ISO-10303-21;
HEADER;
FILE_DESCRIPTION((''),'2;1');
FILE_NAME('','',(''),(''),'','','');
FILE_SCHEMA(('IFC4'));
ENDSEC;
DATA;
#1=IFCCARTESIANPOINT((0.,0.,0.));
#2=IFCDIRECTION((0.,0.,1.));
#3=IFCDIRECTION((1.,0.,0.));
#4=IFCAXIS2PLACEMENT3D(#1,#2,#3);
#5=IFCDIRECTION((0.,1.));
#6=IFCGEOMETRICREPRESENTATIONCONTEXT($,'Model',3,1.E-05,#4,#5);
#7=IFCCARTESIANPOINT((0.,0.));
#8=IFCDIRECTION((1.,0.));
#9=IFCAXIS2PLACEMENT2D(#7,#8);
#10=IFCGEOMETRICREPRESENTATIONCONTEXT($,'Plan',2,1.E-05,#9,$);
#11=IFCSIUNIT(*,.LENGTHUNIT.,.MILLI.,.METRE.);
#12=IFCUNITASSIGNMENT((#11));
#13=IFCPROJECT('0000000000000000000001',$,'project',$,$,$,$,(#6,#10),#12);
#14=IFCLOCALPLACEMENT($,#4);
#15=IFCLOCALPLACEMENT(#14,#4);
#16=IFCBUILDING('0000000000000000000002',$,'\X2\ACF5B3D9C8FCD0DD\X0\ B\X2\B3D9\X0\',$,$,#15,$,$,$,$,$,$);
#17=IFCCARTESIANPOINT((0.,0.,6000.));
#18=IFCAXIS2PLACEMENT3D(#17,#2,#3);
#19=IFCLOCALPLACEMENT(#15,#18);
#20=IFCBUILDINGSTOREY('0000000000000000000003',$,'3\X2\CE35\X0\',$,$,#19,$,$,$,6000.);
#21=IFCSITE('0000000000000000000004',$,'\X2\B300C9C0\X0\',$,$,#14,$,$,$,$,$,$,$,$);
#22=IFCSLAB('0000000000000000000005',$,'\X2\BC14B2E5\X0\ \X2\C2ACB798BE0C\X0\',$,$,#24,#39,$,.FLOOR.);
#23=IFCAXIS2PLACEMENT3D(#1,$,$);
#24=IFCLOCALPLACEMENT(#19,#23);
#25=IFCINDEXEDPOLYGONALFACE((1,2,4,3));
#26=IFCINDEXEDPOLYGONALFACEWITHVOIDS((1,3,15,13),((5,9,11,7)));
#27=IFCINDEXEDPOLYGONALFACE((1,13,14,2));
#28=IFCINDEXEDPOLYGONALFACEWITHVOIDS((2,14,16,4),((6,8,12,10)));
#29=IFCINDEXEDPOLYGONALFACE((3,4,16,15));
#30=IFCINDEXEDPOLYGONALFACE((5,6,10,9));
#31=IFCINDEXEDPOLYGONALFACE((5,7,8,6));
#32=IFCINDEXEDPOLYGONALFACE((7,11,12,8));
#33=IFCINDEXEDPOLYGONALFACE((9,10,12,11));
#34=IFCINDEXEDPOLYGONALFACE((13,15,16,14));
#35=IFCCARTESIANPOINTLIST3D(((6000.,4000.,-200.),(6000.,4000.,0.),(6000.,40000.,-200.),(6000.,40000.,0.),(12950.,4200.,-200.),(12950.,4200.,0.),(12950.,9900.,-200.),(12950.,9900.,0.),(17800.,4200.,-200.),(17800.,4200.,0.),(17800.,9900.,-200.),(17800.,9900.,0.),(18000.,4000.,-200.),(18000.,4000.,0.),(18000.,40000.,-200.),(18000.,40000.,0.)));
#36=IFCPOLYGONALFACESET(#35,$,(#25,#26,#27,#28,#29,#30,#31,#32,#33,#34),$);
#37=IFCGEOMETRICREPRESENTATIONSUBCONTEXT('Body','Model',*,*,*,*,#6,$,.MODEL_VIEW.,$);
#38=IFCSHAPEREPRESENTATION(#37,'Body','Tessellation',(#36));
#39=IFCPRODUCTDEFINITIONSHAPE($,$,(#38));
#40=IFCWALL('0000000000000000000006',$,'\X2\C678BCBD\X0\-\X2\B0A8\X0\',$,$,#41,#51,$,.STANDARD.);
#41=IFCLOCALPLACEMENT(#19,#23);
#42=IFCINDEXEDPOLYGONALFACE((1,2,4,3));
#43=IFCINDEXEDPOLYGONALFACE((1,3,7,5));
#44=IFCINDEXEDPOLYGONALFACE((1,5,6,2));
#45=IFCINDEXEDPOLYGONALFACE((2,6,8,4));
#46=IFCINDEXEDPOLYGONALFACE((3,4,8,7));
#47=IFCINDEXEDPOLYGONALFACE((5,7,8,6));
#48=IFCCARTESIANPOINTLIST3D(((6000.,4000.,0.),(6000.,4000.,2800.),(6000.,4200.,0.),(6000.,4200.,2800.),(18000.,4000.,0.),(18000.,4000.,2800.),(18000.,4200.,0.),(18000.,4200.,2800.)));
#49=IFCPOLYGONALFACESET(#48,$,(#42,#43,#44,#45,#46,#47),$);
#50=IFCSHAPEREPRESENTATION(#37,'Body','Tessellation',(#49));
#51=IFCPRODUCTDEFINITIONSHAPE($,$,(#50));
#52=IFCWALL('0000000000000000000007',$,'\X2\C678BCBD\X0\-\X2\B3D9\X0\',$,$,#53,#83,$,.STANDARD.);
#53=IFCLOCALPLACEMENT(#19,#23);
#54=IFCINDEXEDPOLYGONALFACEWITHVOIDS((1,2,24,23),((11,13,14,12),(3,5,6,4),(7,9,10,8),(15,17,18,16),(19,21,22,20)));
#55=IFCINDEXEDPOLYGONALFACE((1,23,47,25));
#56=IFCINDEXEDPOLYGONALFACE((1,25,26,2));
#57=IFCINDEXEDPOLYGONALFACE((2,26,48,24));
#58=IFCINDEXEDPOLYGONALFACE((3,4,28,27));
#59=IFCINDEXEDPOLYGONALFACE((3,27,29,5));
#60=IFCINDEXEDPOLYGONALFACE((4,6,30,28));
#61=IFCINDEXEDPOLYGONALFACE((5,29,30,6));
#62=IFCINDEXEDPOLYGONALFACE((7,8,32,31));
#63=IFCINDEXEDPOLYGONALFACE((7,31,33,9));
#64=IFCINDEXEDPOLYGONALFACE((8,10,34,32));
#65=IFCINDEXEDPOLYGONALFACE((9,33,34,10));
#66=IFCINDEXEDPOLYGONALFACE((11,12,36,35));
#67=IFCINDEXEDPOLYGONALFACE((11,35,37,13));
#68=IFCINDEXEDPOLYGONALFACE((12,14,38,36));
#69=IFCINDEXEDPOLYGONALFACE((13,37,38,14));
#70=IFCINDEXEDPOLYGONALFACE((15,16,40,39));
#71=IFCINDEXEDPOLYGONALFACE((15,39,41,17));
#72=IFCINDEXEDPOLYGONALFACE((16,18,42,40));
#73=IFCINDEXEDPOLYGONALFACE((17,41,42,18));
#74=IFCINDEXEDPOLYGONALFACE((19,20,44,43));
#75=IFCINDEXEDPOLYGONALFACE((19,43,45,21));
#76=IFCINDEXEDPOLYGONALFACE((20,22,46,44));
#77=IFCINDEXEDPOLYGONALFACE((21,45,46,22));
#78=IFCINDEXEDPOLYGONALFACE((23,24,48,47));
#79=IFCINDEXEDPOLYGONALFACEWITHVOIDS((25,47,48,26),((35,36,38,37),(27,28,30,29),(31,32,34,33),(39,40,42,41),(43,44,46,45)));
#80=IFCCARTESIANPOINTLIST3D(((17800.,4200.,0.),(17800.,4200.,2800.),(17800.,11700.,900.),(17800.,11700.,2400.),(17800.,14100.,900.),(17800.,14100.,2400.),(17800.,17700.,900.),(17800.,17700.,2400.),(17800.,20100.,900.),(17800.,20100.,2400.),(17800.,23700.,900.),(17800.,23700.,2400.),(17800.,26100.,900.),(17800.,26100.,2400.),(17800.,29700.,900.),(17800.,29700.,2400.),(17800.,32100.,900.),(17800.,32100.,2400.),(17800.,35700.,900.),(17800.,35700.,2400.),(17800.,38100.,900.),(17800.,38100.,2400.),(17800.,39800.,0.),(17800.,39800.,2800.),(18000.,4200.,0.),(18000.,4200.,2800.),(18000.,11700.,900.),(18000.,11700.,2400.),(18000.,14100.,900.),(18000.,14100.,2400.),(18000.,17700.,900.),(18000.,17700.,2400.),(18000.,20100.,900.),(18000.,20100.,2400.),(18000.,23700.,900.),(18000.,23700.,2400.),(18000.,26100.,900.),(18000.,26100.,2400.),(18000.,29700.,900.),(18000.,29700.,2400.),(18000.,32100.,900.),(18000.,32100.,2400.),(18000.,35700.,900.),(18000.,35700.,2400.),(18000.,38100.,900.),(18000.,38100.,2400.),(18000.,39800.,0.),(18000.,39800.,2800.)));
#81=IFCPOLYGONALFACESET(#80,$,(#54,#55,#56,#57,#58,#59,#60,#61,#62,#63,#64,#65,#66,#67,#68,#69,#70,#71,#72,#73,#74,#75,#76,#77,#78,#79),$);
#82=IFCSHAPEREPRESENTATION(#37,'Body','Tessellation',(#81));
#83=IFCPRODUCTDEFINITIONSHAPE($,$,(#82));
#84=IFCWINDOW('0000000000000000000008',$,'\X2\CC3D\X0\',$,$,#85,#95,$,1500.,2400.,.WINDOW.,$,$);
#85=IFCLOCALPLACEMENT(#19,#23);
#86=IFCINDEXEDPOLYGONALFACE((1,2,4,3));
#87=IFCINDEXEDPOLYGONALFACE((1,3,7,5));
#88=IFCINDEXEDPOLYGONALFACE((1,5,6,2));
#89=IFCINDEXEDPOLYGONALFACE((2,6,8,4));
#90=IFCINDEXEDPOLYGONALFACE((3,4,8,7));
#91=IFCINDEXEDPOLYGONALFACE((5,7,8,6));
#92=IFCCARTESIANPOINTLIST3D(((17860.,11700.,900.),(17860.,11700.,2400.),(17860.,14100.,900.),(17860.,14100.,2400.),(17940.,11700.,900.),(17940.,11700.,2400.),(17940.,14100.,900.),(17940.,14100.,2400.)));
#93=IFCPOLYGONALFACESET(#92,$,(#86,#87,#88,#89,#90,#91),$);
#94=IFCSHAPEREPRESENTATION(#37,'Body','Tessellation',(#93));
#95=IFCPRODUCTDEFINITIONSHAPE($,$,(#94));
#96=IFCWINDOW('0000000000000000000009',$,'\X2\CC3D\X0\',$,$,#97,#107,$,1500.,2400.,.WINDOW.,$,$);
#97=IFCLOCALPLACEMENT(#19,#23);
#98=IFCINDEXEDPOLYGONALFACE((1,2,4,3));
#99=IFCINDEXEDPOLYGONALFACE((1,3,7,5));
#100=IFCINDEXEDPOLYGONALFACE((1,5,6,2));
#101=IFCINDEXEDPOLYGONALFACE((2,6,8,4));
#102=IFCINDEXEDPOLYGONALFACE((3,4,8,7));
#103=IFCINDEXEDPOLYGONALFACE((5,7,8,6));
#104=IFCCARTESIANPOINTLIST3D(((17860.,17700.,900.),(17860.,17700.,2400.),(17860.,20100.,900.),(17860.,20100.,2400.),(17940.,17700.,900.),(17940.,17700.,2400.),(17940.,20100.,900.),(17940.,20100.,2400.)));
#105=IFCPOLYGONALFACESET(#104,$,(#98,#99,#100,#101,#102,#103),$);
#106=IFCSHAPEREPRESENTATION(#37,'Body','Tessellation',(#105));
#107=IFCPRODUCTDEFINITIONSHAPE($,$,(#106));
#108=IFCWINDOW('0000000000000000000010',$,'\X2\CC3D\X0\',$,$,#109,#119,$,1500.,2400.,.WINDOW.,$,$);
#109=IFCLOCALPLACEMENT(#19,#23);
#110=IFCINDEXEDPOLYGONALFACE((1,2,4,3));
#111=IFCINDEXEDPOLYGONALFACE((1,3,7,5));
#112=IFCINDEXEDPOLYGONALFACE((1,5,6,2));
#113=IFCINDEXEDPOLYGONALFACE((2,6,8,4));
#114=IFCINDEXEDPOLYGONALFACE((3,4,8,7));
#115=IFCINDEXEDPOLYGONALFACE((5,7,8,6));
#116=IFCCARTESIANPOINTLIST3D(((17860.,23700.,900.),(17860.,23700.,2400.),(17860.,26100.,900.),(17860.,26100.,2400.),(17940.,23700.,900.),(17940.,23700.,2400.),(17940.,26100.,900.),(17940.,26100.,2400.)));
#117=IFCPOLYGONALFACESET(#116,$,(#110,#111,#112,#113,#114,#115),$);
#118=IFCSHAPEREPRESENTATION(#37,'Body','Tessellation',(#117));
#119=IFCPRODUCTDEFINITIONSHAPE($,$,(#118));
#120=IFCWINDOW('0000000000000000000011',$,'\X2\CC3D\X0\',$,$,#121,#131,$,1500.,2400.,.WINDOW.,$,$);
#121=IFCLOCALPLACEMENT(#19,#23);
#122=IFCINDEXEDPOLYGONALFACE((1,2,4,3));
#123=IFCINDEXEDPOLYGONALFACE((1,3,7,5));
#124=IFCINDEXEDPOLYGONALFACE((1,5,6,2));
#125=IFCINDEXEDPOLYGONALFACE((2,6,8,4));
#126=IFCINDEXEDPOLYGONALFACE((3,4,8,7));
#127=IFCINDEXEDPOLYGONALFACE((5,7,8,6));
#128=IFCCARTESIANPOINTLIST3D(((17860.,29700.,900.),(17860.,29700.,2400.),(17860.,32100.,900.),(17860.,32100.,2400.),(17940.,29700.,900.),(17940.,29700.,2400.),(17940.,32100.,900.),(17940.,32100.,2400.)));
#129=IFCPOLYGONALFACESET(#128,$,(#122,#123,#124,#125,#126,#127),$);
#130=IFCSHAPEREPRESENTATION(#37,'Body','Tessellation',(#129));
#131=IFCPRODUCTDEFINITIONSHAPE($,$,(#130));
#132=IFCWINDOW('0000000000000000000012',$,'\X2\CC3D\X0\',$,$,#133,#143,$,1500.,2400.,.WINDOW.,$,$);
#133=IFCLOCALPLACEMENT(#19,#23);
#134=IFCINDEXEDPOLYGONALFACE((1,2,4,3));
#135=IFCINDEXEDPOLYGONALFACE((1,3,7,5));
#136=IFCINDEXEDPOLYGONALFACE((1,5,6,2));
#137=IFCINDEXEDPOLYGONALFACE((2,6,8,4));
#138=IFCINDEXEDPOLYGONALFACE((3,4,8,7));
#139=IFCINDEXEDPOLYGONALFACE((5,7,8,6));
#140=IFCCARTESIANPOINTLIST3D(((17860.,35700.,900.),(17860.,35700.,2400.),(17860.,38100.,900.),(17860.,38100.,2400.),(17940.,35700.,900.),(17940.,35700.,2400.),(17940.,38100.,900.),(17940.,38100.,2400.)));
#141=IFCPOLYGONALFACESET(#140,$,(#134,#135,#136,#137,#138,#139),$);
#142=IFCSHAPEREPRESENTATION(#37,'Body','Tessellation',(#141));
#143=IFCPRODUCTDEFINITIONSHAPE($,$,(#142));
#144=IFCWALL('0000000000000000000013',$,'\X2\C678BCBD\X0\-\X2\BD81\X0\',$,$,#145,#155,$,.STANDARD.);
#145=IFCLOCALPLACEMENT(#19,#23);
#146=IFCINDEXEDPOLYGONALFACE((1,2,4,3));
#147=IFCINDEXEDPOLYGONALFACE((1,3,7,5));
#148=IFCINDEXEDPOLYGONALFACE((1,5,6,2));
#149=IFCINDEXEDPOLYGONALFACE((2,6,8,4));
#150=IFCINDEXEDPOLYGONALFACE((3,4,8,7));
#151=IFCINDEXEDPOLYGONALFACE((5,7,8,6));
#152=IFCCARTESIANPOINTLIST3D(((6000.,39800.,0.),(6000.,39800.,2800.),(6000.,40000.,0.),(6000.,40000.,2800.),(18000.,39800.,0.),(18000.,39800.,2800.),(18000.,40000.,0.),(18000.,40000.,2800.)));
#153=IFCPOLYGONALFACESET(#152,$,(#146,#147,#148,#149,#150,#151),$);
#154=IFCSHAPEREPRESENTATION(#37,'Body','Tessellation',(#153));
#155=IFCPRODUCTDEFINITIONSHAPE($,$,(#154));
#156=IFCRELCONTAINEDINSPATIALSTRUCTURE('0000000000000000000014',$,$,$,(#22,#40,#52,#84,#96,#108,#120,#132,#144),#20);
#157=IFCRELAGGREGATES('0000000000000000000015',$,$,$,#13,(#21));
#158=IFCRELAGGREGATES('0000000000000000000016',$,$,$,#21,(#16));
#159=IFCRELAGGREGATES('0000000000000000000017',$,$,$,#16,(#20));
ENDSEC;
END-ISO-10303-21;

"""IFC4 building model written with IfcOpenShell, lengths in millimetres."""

from ifc_helpers import new_model, si_unit, direction, frame, origin_with_axes, origin_2d_with_axis, place, context, subcontext, project, spatial, polyline, outline, extrude, element, fill, save


model = new_model("IFC4")

# Units and contexts
model_context = context("Model", 3, precision=1e-05, world=origin_with_axes(), true_north=direction((0.0, 1.0)))
plan_context = context("Plan", 2, precision=1e-05, world=origin_2d_with_axis())
body_context = subcontext(model_context, "Body", "Model", "MODEL_VIEW")
ifc_project = project(units=[si_unit("LENGTHUNIT", "METRE", prefix="MILLI")], contexts=[model_context, plan_context])

# Site, building, storey
site_placement = place(None, origin_with_axes())
site = spatial("IfcSite", under=ifc_project, at=site_placement, Name="대지")
building_placement = place(site_placement, origin_with_axes())
building = spatial("IfcBuilding", under=site, at=building_placement, Name="공동주택 B동")
storey_placement = place(building_placement, frame((0.0, 0.0, 6000.0), z_axis=(0.0, 0.0, 1.0), x_axis=(1.0, 0.0, 0.0)))
storey = spatial("IfcBuildingStorey", under=building, at=storey_placement, Name="3층", Elevation=6000.0)

# Slab
slab_placement = place(storey_placement, origin_with_axes())
element("IfcSlab", 1, at=slab_placement, inside=storey, Name="바닥 슬래브", PredefinedType="FLOOR", context=body_context, shape_type="SweptSolid", body=[
    extrude(outline(polyline([(6000.0, 4000.0), (18000.0, 4000.0), (18000.0, 40000.0), (6000.0, 40000.0), (6000.0, 4000.0)]), holes=[polyline([(12950.0, 4200.0), (17800.0, 4200.0), (17800.0, 9900.0), (12950.0, 9900.0), (12950.0, 4200.0)])]), frame((0.0, 0.0, -200.0), z_axis=(0.0, 0.0, 1.0), x_axis=(1.0, 0.0, 0.0)), (0.0, 0.0, 1.0), 200.0),
])

# Wall
wall_1_placement = place(storey_placement, origin_with_axes())
element("IfcWall", 2, at=wall_1_placement, inside=storey, Name="외벽-남", PredefinedType="STANDARD", context=body_context, shape_type="SweptSolid", body=[
    extrude(outline(polyline([(6000.0, 4200.0), (18000.0, 4200.0), (18000.0, 4000.0), (6000.0, 4000.0), (6000.0, 4200.0)])), origin_with_axes(), (0.0, 0.0, 1.0), 2800.0),
])

# Wall, openings, windows
wall_2_placement = place(storey_placement, origin_with_axes())
wall_2 = element("IfcWall", 3, at=wall_2_placement, inside=storey, Name="외벽-동", PredefinedType="STANDARD", context=body_context, shape_type="SweptSolid", body=[
    extrude(outline(polyline([(17800.0, 4200.0), (17800.0, 39800.0), (18000.0, 39800.0), (18000.0, 4200.0), (17800.0, 4200.0)])), origin_with_axes(), (0.0, 0.0, 1.0), 2800.0),
])
opening_1_placement = place(storey_placement, origin_with_axes())
opening_1 = element("IfcOpeningElement", 4, at=opening_1_placement, cuts=wall_2, PredefinedType="OPENING", context=body_context, shape_type="SweptSolid", body=[
    extrude(outline(polyline([(18050.0, 11700.0), (18050.0, 14100.0), (17750.0, 14100.0), (17750.0, 11700.0), (18050.0, 11700.0)])), frame((0.0, 0.0, 900.0), z_axis=(0.0, 0.0, 1.0), x_axis=(1.0, 0.0, 0.0)), (0.0, 0.0, 1.0), 1500.0),
])
opening_2_placement = place(storey_placement, origin_with_axes())
opening_2 = element("IfcOpeningElement", 5, at=opening_2_placement, cuts=wall_2, PredefinedType="OPENING", context=body_context, shape_type="SweptSolid", body=[
    extrude(outline(polyline([(18050.0, 17700.0), (18050.0, 20100.0), (17750.0, 20100.0), (17750.0, 17700.0), (18050.0, 17700.0)])), frame((0.0, 0.0, 900.0), z_axis=(0.0, 0.0, 1.0), x_axis=(1.0, 0.0, 0.0)), (0.0, 0.0, 1.0), 1500.0),
])
opening_3_placement = place(storey_placement, origin_with_axes())
opening_3 = element("IfcOpeningElement", 6, at=opening_3_placement, cuts=wall_2, PredefinedType="OPENING", context=body_context, shape_type="SweptSolid", body=[
    extrude(outline(polyline([(18050.0, 23700.0), (18050.0, 26100.0), (17750.0, 26100.0), (17750.0, 23700.0), (18050.0, 23700.0)])), frame((0.0, 0.0, 900.0), z_axis=(0.0, 0.0, 1.0), x_axis=(1.0, 0.0, 0.0)), (0.0, 0.0, 1.0), 1500.0),
])
opening_4_placement = place(storey_placement, origin_with_axes())
opening_4 = element("IfcOpeningElement", 7, at=opening_4_placement, cuts=wall_2, PredefinedType="OPENING", context=body_context, shape_type="SweptSolid", body=[
    extrude(outline(polyline([(18050.0, 29700.0), (18050.0, 32100.0), (17750.0, 32100.0), (17750.0, 29700.0), (18050.0, 29700.0)])), frame((0.0, 0.0, 900.0), z_axis=(0.0, 0.0, 1.0), x_axis=(1.0, 0.0, 0.0)), (0.0, 0.0, 1.0), 1500.0),
])
opening_5_placement = place(storey_placement, origin_with_axes())
opening_5 = element("IfcOpeningElement", 8, at=opening_5_placement, cuts=wall_2, PredefinedType="OPENING", context=body_context, shape_type="SweptSolid", body=[
    extrude(outline(polyline([(18050.0, 35700.0), (18050.0, 38100.0), (17750.0, 38100.0), (17750.0, 35700.0), (18050.0, 35700.0)])), frame((0.0, 0.0, 900.0), z_axis=(0.0, 0.0, 1.0), x_axis=(1.0, 0.0, 0.0)), (0.0, 0.0, 1.0), 1500.0),
])
window_1_placement = place(storey_placement, origin_with_axes())
window_1 = element("IfcWindow", 9, at=window_1_placement, inside=storey, Name="창", OverallHeight=1500.0, OverallWidth=2400.0, PredefinedType="WINDOW", context=body_context, shape_type="SweptSolid", body=[
    extrude(outline(polyline([(17940.0, 11700.0), (17940.0, 14100.0), (17860.0, 14100.0), (17860.0, 11700.0), (17940.0, 11700.0)])), frame((0.0, 0.0, 900.0), z_axis=(0.0, 0.0, 1.0), x_axis=(1.0, 0.0, 0.0)), (0.0, 0.0, 1.0), 1500.0),
])
fill(opening_1, window_1)
window_2_placement = place(storey_placement, origin_with_axes())
window_2 = element("IfcWindow", 10, at=window_2_placement, inside=storey, Name="창", OverallHeight=1500.0, OverallWidth=2400.0, PredefinedType="WINDOW", context=body_context, shape_type="SweptSolid", body=[
    extrude(outline(polyline([(17940.0, 17700.0), (17940.0, 20100.0), (17860.0, 20100.0), (17860.0, 17700.0), (17940.0, 17700.0)])), frame((0.0, 0.0, 900.0), z_axis=(0.0, 0.0, 1.0), x_axis=(1.0, 0.0, 0.0)), (0.0, 0.0, 1.0), 1500.0),
])
fill(opening_2, window_2)
window_3_placement = place(storey_placement, origin_with_axes())
window_3 = element("IfcWindow", 11, at=window_3_placement, inside=storey, Name="창", OverallHeight=1500.0, OverallWidth=2400.0, PredefinedType="WINDOW", context=body_context, shape_type="SweptSolid", body=[
    extrude(outline(polyline([(17940.0, 23700.0), (17940.0, 26100.0), (17860.0, 26100.0), (17860.0, 23700.0), (17940.0, 23700.0)])), frame((0.0, 0.0, 900.0), z_axis=(0.0, 0.0, 1.0), x_axis=(1.0, 0.0, 0.0)), (0.0, 0.0, 1.0), 1500.0),
])
fill(opening_3, window_3)
window_4_placement = place(storey_placement, origin_with_axes())
window_4 = element("IfcWindow", 12, at=window_4_placement, inside=storey, Name="창", OverallHeight=1500.0, OverallWidth=2400.0, PredefinedType="WINDOW", context=body_context, shape_type="SweptSolid", body=[
    extrude(outline(polyline([(17940.0, 29700.0), (17940.0, 32100.0), (17860.0, 32100.0), (17860.0, 29700.0), (17940.0, 29700.0)])), frame((0.0, 0.0, 900.0), z_axis=(0.0, 0.0, 1.0), x_axis=(1.0, 0.0, 0.0)), (0.0, 0.0, 1.0), 1500.0),
])
fill(opening_4, window_4)
window_5_placement = place(storey_placement, origin_with_axes())
window_5 = element("IfcWindow", 13, at=window_5_placement, inside=storey, Name="창", OverallHeight=1500.0, OverallWidth=2400.0, PredefinedType="WINDOW", context=body_context, shape_type="SweptSolid", body=[
    extrude(outline(polyline([(17940.0, 35700.0), (17940.0, 38100.0), (17860.0, 38100.0), (17860.0, 35700.0), (17940.0, 35700.0)])), frame((0.0, 0.0, 900.0), z_axis=(0.0, 0.0, 1.0), x_axis=(1.0, 0.0, 0.0)), (0.0, 0.0, 1.0), 1500.0),
])
fill(opening_5, window_5)

# Wall
wall_3_placement = place(storey_placement, origin_with_axes())
element("IfcWall", 14, at=wall_3_placement, inside=storey, Name="외벽-북", PredefinedType="STANDARD", context=body_context, shape_type="SweptSolid", body=[
    extrude(outline(polyline([(18000.0, 39800.0), (6000.0, 39800.0), (6000.0, 40000.0), (18000.0, 40000.0), (18000.0, 39800.0)])), origin_with_axes(), (0.0, 0.0, 1.0), 2800.0),
])

save(model, "model.ifc")
